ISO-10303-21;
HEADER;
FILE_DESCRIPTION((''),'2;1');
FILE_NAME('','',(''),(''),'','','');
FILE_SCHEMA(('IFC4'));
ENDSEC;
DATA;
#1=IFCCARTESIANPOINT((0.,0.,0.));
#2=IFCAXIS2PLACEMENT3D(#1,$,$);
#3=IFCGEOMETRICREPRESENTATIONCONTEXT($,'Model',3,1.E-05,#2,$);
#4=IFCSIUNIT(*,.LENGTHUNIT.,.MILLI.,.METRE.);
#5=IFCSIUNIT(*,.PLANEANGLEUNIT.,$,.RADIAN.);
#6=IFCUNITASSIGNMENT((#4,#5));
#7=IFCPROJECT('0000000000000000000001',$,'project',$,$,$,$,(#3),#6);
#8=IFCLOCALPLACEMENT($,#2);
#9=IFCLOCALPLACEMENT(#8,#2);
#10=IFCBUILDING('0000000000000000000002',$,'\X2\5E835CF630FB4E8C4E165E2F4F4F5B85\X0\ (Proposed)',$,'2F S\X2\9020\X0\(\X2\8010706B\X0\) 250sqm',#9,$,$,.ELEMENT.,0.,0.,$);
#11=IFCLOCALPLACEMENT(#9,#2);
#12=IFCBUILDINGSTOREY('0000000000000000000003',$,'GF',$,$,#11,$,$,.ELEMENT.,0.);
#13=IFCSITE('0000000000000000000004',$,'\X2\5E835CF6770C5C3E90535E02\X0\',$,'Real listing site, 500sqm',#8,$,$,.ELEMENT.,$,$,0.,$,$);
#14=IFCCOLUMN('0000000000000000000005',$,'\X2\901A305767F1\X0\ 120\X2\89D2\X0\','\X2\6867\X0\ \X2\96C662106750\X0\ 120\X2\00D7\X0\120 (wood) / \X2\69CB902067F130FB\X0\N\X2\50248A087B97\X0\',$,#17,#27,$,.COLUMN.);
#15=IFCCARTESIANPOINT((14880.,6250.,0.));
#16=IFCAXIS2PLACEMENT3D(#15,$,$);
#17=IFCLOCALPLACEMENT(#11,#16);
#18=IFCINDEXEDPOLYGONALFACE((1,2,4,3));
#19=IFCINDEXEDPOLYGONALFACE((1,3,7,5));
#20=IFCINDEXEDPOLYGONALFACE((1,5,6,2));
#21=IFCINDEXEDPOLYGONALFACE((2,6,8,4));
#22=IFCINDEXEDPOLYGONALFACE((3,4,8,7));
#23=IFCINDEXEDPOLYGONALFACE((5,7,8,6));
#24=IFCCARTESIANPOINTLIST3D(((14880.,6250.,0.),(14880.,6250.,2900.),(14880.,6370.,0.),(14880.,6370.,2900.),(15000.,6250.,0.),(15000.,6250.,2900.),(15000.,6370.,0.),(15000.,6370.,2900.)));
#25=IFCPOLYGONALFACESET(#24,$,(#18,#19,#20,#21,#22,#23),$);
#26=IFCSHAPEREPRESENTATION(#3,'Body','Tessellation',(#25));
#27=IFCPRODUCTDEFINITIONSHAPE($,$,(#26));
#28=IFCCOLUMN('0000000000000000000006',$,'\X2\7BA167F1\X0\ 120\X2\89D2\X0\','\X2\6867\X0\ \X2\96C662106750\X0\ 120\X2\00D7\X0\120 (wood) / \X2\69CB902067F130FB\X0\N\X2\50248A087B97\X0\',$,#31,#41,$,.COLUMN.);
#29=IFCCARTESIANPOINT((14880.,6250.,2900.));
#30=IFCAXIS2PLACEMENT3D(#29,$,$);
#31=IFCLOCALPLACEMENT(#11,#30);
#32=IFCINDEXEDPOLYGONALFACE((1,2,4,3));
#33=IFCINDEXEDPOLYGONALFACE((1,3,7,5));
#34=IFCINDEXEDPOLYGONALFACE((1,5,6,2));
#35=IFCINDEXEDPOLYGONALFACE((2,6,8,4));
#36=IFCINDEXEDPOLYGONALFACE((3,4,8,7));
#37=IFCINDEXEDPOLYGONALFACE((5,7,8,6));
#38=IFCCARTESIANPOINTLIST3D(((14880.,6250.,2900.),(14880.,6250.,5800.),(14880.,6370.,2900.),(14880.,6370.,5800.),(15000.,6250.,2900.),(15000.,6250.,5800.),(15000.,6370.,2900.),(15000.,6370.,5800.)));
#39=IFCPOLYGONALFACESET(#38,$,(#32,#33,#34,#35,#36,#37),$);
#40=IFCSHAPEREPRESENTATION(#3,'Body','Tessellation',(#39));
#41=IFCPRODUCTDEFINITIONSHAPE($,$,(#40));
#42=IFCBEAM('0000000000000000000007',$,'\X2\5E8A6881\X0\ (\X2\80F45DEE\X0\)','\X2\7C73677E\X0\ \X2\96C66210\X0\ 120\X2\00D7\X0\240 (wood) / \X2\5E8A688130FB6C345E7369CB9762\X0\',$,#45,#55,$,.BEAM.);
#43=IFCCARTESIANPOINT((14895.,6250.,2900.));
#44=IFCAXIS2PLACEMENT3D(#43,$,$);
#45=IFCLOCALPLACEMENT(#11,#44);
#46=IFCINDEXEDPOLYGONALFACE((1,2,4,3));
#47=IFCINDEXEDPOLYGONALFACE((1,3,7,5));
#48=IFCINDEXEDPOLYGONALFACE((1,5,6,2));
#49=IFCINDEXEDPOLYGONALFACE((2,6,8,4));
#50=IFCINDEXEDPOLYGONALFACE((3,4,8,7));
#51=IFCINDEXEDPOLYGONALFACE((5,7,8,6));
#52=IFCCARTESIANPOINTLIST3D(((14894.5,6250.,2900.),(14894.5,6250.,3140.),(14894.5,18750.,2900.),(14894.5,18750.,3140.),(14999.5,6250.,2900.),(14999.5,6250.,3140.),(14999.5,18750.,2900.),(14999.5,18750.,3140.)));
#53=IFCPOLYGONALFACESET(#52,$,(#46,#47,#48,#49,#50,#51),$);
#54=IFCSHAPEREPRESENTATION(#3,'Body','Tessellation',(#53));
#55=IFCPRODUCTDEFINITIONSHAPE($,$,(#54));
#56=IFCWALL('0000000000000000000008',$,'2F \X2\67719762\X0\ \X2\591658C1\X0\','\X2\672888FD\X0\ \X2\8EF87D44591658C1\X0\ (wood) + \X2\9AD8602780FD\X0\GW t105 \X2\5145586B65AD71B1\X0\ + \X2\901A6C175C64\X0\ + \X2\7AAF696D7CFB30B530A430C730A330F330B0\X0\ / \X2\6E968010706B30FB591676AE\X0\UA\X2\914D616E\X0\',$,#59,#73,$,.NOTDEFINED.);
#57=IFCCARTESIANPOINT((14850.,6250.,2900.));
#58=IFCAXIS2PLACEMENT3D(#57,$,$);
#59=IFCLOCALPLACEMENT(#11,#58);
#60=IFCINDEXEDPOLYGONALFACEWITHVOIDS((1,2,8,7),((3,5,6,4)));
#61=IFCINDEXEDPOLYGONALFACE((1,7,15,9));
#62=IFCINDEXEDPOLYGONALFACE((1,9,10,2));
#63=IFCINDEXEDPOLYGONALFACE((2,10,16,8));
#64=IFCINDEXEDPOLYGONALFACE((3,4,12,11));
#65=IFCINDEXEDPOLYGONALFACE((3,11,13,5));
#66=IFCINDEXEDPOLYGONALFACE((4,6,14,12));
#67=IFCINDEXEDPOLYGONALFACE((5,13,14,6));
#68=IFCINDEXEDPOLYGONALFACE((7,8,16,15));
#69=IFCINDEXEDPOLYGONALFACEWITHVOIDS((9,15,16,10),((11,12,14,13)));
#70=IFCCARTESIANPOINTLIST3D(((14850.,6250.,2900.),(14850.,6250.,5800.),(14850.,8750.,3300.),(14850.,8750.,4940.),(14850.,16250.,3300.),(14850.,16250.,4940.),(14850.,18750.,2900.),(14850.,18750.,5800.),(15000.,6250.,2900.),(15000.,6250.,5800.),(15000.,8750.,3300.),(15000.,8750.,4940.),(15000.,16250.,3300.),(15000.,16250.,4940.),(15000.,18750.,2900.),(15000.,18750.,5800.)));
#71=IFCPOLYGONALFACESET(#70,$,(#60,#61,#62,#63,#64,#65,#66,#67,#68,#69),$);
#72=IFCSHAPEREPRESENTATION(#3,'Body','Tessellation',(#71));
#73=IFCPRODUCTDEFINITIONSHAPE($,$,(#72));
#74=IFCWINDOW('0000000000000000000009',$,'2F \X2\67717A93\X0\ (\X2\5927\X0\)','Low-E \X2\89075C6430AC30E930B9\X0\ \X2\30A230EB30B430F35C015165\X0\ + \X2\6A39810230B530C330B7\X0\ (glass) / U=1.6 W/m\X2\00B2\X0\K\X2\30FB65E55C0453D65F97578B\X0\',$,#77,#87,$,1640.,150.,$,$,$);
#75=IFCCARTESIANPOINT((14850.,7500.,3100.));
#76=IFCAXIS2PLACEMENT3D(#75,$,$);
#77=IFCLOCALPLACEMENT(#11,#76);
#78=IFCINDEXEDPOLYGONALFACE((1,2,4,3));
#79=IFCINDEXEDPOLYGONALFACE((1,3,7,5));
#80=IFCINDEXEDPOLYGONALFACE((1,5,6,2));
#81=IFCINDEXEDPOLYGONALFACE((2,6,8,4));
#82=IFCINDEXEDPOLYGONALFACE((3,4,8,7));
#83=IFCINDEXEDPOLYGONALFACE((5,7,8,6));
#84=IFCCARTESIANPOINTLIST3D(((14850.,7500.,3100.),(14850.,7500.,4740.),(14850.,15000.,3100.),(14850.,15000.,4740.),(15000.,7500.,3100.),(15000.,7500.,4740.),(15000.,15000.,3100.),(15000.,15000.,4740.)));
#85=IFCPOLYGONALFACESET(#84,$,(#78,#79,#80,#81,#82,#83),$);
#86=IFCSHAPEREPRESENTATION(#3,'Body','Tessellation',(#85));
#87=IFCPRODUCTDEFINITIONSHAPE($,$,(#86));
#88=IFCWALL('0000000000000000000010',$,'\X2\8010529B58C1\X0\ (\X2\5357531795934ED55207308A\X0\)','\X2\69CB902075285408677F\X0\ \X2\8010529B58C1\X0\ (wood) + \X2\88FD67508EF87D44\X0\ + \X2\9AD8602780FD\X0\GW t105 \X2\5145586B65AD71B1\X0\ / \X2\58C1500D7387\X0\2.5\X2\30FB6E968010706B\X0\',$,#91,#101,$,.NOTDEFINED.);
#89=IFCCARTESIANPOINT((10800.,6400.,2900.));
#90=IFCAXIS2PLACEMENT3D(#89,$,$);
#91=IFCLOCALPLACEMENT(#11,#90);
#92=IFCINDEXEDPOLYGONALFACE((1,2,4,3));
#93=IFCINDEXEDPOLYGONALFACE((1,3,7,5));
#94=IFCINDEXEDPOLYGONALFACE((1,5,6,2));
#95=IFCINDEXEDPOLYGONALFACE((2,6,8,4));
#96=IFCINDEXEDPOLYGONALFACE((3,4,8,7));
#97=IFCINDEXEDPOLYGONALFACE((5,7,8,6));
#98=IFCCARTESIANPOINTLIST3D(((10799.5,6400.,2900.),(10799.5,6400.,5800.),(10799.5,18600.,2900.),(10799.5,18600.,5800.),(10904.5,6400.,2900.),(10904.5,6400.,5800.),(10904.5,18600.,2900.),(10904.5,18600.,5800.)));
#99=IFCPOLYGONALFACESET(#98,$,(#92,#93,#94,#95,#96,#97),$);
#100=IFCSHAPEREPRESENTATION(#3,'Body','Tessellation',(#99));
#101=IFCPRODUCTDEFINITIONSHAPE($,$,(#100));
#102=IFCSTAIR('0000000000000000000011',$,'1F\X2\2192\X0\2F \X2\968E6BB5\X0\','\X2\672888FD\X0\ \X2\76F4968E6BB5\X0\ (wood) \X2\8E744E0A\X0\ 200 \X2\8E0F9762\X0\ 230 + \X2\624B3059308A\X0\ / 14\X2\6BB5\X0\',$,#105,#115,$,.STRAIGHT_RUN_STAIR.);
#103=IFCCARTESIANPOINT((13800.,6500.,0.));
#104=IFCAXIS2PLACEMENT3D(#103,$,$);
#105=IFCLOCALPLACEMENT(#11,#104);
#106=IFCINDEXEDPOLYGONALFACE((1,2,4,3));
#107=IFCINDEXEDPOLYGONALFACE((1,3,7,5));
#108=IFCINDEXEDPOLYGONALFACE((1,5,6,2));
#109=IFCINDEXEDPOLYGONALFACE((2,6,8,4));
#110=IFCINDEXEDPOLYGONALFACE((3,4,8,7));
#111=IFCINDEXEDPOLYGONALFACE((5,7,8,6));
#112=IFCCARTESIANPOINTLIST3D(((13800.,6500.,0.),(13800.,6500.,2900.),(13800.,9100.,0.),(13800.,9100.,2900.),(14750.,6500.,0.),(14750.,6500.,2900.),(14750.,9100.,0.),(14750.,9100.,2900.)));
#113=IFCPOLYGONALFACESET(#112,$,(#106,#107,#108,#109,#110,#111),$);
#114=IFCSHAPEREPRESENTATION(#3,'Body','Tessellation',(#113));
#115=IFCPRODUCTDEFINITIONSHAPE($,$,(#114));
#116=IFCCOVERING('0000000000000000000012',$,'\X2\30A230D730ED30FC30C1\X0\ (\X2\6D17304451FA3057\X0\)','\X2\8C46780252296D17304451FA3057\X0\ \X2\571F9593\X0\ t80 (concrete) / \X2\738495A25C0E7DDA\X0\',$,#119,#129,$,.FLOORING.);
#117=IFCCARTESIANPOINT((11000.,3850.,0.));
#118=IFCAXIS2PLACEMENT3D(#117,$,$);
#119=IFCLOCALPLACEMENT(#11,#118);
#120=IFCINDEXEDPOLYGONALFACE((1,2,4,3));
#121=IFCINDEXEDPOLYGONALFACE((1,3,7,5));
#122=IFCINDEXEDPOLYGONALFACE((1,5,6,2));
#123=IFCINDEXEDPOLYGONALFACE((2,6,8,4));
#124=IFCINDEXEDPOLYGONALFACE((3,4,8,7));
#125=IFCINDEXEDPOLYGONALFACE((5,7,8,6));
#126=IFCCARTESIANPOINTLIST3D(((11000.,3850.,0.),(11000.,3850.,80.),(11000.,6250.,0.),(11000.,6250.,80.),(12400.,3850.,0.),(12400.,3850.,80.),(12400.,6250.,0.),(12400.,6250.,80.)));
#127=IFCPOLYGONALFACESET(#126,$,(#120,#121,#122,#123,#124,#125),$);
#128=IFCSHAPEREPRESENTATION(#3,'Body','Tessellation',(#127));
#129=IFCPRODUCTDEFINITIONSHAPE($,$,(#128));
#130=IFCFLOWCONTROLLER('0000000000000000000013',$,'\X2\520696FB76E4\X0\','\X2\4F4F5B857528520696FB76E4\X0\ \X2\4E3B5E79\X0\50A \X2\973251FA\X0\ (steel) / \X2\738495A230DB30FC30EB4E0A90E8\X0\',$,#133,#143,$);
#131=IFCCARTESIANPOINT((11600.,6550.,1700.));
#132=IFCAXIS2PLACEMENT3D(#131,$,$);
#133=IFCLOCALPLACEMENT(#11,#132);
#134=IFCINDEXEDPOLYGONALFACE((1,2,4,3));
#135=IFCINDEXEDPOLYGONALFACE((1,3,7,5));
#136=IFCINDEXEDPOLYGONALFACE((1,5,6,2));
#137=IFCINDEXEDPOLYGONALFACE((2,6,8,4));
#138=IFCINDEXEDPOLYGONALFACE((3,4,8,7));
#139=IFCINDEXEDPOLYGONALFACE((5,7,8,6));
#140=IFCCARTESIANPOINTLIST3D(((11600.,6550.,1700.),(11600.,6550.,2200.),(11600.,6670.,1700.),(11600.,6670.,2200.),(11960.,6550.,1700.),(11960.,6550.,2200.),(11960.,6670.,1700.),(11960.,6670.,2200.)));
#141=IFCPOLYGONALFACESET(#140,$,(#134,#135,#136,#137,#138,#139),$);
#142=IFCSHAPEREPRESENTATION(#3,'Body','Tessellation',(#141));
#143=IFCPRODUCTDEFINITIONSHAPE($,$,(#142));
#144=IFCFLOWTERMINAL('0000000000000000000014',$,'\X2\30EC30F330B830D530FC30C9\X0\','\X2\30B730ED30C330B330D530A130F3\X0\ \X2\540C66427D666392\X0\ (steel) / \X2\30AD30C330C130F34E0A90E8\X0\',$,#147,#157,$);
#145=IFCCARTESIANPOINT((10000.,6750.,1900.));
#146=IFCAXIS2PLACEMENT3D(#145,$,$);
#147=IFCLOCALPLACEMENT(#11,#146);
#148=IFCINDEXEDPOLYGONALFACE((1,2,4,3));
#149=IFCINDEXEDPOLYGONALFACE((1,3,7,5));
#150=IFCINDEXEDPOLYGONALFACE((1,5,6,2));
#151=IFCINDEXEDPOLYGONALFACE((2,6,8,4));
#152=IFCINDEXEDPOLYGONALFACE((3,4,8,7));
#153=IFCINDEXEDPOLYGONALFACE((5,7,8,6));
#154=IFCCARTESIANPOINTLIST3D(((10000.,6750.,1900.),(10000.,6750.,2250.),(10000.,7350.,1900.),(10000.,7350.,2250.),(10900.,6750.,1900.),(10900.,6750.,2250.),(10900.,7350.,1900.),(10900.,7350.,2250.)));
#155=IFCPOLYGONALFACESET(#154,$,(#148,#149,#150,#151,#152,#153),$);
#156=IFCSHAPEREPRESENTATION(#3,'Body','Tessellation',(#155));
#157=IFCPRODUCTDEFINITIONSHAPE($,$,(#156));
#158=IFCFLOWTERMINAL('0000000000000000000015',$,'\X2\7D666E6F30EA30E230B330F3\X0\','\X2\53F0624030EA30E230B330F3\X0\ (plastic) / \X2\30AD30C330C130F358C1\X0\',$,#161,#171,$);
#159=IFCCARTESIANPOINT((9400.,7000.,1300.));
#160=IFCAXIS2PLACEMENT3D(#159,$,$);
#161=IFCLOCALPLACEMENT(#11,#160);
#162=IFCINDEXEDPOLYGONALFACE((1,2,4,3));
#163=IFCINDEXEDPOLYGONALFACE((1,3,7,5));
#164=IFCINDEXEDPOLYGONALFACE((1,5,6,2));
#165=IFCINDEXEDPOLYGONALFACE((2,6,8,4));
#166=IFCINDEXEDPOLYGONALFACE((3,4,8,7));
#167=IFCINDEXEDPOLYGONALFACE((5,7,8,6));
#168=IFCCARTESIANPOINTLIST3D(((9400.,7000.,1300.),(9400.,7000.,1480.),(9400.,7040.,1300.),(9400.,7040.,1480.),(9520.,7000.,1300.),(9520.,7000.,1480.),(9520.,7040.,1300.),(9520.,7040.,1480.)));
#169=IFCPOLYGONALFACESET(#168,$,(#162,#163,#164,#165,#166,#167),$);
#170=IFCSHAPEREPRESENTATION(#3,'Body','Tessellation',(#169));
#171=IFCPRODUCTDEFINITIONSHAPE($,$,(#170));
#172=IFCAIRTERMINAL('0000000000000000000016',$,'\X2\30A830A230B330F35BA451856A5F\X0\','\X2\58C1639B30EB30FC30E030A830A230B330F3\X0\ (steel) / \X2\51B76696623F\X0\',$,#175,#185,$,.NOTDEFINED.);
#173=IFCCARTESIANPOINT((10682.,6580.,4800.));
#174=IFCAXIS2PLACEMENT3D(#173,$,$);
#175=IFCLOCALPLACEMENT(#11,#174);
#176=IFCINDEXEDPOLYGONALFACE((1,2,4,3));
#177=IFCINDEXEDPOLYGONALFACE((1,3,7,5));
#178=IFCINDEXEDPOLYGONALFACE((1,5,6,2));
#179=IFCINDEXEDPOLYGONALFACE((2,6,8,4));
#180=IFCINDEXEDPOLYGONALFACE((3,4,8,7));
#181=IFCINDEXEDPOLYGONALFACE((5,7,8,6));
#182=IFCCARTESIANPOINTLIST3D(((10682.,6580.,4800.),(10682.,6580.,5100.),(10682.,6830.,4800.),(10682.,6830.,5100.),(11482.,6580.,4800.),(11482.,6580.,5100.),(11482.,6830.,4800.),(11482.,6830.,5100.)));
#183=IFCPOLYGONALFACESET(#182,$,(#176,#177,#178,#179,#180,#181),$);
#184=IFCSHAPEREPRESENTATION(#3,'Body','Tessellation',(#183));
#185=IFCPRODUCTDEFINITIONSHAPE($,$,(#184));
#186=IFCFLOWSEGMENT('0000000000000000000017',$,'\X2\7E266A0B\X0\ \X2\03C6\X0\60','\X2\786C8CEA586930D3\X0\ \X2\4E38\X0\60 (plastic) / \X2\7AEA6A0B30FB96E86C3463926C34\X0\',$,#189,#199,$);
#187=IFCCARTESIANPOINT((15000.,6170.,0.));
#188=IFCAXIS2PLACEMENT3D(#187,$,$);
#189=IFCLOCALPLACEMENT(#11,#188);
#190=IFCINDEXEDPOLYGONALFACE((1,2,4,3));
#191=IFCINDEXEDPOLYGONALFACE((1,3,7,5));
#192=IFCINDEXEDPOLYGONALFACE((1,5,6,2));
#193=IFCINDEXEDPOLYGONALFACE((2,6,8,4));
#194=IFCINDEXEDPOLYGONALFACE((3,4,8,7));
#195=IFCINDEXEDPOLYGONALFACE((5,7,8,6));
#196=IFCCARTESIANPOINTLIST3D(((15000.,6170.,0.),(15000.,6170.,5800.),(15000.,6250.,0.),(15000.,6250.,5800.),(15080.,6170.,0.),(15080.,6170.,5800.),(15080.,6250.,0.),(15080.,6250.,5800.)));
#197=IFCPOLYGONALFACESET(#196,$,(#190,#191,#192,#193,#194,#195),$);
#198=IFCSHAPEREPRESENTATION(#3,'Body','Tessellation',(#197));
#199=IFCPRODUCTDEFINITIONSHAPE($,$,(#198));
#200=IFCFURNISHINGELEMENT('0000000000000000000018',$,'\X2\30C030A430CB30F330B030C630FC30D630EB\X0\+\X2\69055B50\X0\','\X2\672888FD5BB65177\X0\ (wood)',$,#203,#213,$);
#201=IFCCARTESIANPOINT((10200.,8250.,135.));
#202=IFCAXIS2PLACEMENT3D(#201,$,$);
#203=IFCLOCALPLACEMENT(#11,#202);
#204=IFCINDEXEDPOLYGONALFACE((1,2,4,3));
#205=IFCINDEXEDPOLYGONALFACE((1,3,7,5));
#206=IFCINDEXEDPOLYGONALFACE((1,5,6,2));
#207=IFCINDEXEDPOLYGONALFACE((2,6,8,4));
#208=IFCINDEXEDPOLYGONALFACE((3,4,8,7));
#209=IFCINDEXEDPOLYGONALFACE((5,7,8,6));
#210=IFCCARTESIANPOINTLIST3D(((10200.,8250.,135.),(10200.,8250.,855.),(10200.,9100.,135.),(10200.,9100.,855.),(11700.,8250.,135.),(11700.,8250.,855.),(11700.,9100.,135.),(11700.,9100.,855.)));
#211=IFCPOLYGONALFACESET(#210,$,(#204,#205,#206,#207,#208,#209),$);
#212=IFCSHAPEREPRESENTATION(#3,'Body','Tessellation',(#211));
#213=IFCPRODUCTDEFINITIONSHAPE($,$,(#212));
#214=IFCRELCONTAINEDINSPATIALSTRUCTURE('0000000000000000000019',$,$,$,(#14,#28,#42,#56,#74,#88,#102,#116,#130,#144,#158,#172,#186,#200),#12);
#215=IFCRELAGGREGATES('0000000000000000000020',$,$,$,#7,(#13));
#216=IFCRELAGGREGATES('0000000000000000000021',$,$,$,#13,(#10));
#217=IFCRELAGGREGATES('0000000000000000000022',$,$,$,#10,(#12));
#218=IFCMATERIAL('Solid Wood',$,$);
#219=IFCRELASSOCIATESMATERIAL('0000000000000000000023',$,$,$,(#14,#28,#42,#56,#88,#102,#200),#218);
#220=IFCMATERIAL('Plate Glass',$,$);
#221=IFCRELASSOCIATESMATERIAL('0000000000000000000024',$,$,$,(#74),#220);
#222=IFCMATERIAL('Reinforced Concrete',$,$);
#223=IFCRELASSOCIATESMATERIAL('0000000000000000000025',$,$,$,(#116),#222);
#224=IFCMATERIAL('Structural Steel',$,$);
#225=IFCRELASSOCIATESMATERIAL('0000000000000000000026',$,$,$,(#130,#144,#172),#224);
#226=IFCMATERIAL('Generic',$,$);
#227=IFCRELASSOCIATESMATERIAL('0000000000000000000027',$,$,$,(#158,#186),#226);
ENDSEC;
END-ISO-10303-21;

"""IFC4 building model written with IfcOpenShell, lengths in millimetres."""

from ifc_helpers import new_model, si_unit, frame, frame_2d, origin, place, context, project, spatial, rectangle, extrude, material, element, fill, save


model = new_model("IFC4")

# Units and contexts
model_context = context("Model", 3, precision=1e-05, world=origin())
ifc_project = project(units=[si_unit("LENGTHUNIT", "METRE", prefix="MILLI"), si_unit("PLANEANGLEUNIT", "RADIAN")], contexts=[model_context])

# Site, building, storey
site_placement = place(None, origin())
site = spatial("IfcSite", under=ifc_project, at=site_placement, Name="広島県尾道市", ObjectType="Real listing site, 500sqm", CompositionType="ELEMENT", RefElevation=0.0)
building_placement = place(site_placement, origin())
building = spatial("IfcBuilding", under=site, at=building_placement, Name="広島・二世帯住宅 (Proposed)", ObjectType="2F S造(耐火) 250sqm", CompositionType="ELEMENT", ElevationOfRefHeight=0.0, ElevationOfTerrain=0.0)
storey_placement = place(building_placement, origin())
storey = spatial("IfcBuildingStorey", under=building, at=storey_placement, Name="GF", CompositionType="ELEMENT", Elevation=0.0)

# Columns
ifc_material_1 = material(Name="Solid Wood")
column_1_placement = place(storey_placement, frame((14880.0, 6250.0, 0.0)))
element("IfcColumn", 1, at=column_1_placement, inside=storey, material=ifc_material_1, Name="通し柱 120角", Description="桧 集成材 120×120 (wood) / 構造柱・N値計算", PredefinedType="COLUMN", context=model_context, shape_type="SweptSolid", body=[
    extrude(rectangle(XDim=120.0, YDim=120.0, at=frame_2d((60.0, 60.0))), frame((14880.0, 6250.0, 0.0)), (0.0, 0.0, 1.0), 2900.0),
])
column_2_placement = place(storey_placement, frame((14880.0, 6250.0, 2900.0)))
element("IfcColumn", 2, at=column_2_placement, inside=storey, material=ifc_material_1, Name="管柱 120角", Description="桧 集成材 120×120 (wood) / 構造柱・N値計算", PredefinedType="COLUMN", context=model_context, shape_type="SweptSolid", body=[
    extrude(rectangle(XDim=120.0, YDim=120.0, at=frame_2d((60.0, 60.0))), frame((14880.0, 6250.0, 2900.0)), (0.0, 0.0, 1.0), 2900.0),
])

# Beam
beam_1_placement = place(storey_placement, frame((14895.0, 6250.0, 2900.0)))
element("IfcBeam", 3, at=beam_1_placement, inside=storey, material=ifc_material_1, Name="床梁 (胴差)", Description="米松 集成 120×240 (wood) / 床梁・水平構面", PredefinedType="BEAM", context=model_context, shape_type="SweptSolid", body=[
    extrude(rectangle(XDim=105.0, YDim=12500.0, at=frame_2d((52.0, 6250.0))), frame((14895.0, 6250.0, 2900.0)), (0.0, 0.0, 1.0), 240.0),
])

# Shared definitions
ifc_material_2 = material(Name="Plate Glass")

# Wall, opening, window
wall_1_placement = place(storey_placement, frame((14850.0, 6250.0, 2900.0)))
wall_1 = element("IfcWall", 4, at=wall_1_placement, inside=storey, material=ifc_material_1, Name="2F 東面 外壁", Description="木製 軸組外壁 (wood) + 高性能GW t105 充填断熱 + 通気層 + 窯業系サイディング / 準耐火・外皮UA配慮", PredefinedType="NOTDEFINED", context=model_context, shape_type="SweptSolid", body=[
    extrude(rectangle(XDim=150.0, YDim=12500.0, at=frame_2d((75.0, 6250.0))), frame((14850.0, 6250.0, 2900.0)), (0.0, 0.0, 1.0), 2900.0),
])
opening_1_placement = place(storey_placement, frame((14850.0, 7500.0, 3100.0)))
opening_1 = element("IfcOpeningElement", 5, at=opening_1_placement, cuts=wall_1, PredefinedType="NOTDEFINED", context=model_context, shape_type="SweptSolid", body=[
    extrude(rectangle(XDim=150.0, YDim=7500.0, at=frame_2d((75.0, 3750.0))), frame((14850.0, 7500.0, 3100.0)), (0.0, 0.0, 1.0), 1640.0),
])
window_1_placement = place(storey_placement, frame((14850.0, 7500.0, 3100.0)))
window_1 = element("IfcWindow", 6, at=window_1_placement, inside=storey, material=ifc_material_2, Name="2F 東窓 (大)", Description="Low-E 複層ガラス アルゴン封入 + 樹脂サッシ (glass) / U=1.6 W/m²K・日射取得型", OverallHeight=1640.0, OverallWidth=150.0, context=model_context, shape_type="SweptSolid", body=[
    extrude(rectangle(XDim=150.0, YDim=7500.0, at=frame_2d((75.0, 3750.0))), frame((14850.0, 7500.0, 3100.0)), (0.0, 0.0, 1.0), 1640.0),
])
fill(opening_1, window_1)

# Wall
wall_2_placement = place(storey_placement, frame((10800.0, 6400.0, 2900.0)))
element("IfcWall", 7, at=wall_2_placement, inside=storey, material=ifc_material_1, Name="耐力壁 (南北間仕切り)", Description="構造用合板 耐力壁 (wood) + 製材軸組 + 高性能GW t105 充填断熱 / 壁倍率2.5・準耐火", PredefinedType="NOTDEFINED", context=model_context, shape_type="SweptSolid", body=[
    extrude(rectangle(XDim=105.0, YDim=12200.0, at=frame_2d((52.0, 6100.0))), frame((10800.0, 6400.0, 2900.0)), (0.0, 0.0, 1.0), 2900.0),
])

# Stair
stair_placement = place(storey_placement, frame((13800.0, 6500.0, 0.0)))
element("IfcStair", 8, at=stair_placement, inside=storey, material=ifc_material_1, Name="1F→2F 階段", Description="木製 直階段 (wood) 蹴上 200 踏面 230 + 手すり / 14段", PredefinedType="STRAIGHT_RUN_STAIR", context=model_context, shape_type="SweptSolid", body=[
    extrude(rectangle(XDim=950.0, YDim=2600.0, at=frame_2d((475.0, 1300.0))), frame((13800.0, 6500.0, 0.0)), (0.0, 0.0, 1.0), 2900.0),
])

# Covering
ifc_material_3 = material(Name="Reinforced Concrete")
covering_placement = place(storey_placement, frame((11000.0, 3850.0, 0.0)))
element("IfcCovering", 9, at=covering_placement, inside=storey, material=ifc_material_3, Name="アプローチ (洗い出し)", Description="豆砂利洗い出し 土間 t80 (concrete) / 玄関導線", PredefinedType="FLOORING", context=model_context, shape_type="SweptSolid", body=[
    extrude(rectangle(XDim=1400.0, YDim=2400.0, at=frame_2d((700.0, 1200.0))), frame((11000.0, 3850.0, 0.0)), (0.0, 0.0, 1.0), 80.0),
])

# Flow controller
ifc_material_4 = material(Name="Structural Steel")
flow_controller_placement = place(storey_placement, frame((11600.0, 6550.0, 1700.0)))
element("IfcFlowController", 10, at=flow_controller_placement, inside=storey, material=ifc_material_4, Name="分電盤", Description="住宅用分電盤 主幹50A 露出 (steel) / 玄関ホール上部", context=model_context, shape_type="SweptSolid", body=[
    extrude(rectangle(XDim=360.0, YDim=120.0, at=frame_2d((180.0, 60.0))), frame((11600.0, 6550.0, 1700.0)), (0.0, 0.0, 1.0), 500.0),
])

# Flow terminals
flow_terminal_1_placement = place(storey_placement, frame((10000.0, 6750.0, 1900.0)))
element("IfcFlowTerminal", 11, at=flow_terminal_1_placement, inside=storey, material=ifc_material_4, Name="レンジフード", Description="シロッコファン 同時給排 (steel) / キッチン上部", context=model_context, shape_type="SweptSolid", body=[
    extrude(rectangle(XDim=900.0, YDim=600.0, at=frame_2d((450.0, 300.0))), frame((10000.0, 6750.0, 1900.0)), (0.0, 0.0, 1.0), 350.0),
])
ifc_material_5 = material(Name="Generic")
flow_terminal_2_placement = place(storey_placement, frame((9400.0, 7000.0, 1300.0)))
element("IfcFlowTerminal", 12, at=flow_terminal_2_placement, inside=storey, material=ifc_material_5, Name="給湯リモコン", Description="台所リモコン (plastic) / キッチン壁", context=model_context, shape_type="SweptSolid", body=[
    extrude(rectangle(XDim=120.0, YDim=40.0, at=frame_2d((60.0, 20.0))), frame((9400.0, 7000.0, 1300.0)), (0.0, 0.0, 1.0), 180.0),
])

# Air terminal
air_terminal_placement = place(storey_placement, frame((10682.0, 6580.0, 4800.0)))
element("IfcAirTerminal", 13, at=air_terminal_placement, inside=storey, material=ifc_material_4, Name="エアコン室内機", Description="壁掛ルームエアコン (steel) / 冷暖房", PredefinedType="NOTDEFINED", context=model_context, shape_type="SweptSolid", body=[
    extrude(rectangle(XDim=800.0, YDim=250.0, at=frame_2d((400.0, 125.0))), frame((10682.0, 6580.0, 4800.0)), (0.0, 0.0, 1.0), 300.0),
])

# Flow segment
flow_segment_placement = place(storey_placement, frame((15000.0, 6170.0, 0.0)))
element("IfcFlowSegment", 14, at=flow_segment_placement, inside=storey, material=ifc_material_5, Name="縦樋 φ60", Description="硬質塩ビ 丸60 (plastic) / 竪樋・雨水排水", context=model_context, shape_type="SweptSolid", body=[
    extrude(rectangle(XDim=80.0, YDim=80.0, at=frame_2d((40.0, 40.0))), frame((15000.0, 6170.0, 0.0)), (0.0, 0.0, 1.0), 5800.0),
])

# Furnishing element
furnishing_1_placement = place(storey_placement, frame((10200.0, 8250.0, 135.0)))
element("IfcFurnishingElement", 15, at=furnishing_1_placement, inside=storey, material=ifc_material_1, Name="ダイニングテーブル+椅子", Description="木製家具 (wood)", context=model_context, shape_type="SweptSolid", body=[
    extrude(rectangle(XDim=1500.0, YDim=850.0, at=frame_2d((750.0, 425.0))), frame((10200.0, 8250.0, 135.0)), (0.0, 0.0, 1.0), 720.0),
])

save(model, "model.ifc")
